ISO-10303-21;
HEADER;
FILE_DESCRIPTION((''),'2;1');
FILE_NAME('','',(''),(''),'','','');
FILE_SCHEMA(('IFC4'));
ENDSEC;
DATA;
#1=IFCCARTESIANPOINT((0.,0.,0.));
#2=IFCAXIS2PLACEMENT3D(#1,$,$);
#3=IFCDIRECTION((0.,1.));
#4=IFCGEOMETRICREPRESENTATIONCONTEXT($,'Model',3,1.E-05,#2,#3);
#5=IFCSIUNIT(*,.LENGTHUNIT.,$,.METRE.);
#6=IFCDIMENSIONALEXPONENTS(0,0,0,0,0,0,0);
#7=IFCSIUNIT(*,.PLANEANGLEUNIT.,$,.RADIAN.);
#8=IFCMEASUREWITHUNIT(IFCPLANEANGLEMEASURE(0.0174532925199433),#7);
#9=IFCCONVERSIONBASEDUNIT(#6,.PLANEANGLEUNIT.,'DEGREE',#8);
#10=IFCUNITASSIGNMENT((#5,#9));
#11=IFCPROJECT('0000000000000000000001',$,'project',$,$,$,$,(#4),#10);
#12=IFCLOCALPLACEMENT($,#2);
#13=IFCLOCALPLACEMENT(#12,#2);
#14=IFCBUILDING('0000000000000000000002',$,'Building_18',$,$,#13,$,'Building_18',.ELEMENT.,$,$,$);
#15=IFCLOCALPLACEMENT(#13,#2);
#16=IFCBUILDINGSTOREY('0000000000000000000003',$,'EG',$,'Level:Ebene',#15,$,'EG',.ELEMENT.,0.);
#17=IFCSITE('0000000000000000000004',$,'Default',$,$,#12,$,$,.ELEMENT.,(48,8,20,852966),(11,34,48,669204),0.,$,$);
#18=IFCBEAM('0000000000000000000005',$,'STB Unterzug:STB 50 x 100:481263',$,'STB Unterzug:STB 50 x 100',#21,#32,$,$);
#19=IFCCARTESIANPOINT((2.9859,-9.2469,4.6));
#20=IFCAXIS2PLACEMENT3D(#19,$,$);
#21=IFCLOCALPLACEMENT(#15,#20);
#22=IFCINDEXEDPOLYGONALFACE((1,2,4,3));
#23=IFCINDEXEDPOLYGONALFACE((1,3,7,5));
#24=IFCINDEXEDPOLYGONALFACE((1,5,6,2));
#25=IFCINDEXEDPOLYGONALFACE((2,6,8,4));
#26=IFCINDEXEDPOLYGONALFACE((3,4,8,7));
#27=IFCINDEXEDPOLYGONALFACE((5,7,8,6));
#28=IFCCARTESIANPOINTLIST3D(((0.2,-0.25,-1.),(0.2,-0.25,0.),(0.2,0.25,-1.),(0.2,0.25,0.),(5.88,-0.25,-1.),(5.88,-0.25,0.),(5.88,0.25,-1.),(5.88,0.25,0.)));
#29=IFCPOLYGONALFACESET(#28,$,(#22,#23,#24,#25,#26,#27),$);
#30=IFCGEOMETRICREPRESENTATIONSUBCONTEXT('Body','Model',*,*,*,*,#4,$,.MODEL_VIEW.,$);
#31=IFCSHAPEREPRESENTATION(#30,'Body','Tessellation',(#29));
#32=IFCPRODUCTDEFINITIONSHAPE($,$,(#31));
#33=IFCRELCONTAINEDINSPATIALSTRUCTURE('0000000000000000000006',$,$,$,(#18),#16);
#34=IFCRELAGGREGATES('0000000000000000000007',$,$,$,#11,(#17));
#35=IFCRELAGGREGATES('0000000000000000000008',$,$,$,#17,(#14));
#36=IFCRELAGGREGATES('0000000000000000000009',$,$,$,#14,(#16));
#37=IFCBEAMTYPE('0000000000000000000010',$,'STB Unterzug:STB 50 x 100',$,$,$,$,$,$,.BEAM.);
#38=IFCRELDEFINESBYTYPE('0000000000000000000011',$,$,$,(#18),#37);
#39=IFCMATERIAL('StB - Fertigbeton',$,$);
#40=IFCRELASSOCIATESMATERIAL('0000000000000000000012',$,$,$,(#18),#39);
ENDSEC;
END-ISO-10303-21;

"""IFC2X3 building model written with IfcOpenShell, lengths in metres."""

from ifc_helpers import new_model, entity, si_unit, converted_unit, direction, frame, origin, origin_2d_with_axis, place, context, subcontext, project, spatial, rectangle, extrude, material, type_object, element, save


model = new_model("IFC2X3")

# Units and contexts
model_context = context("Model", 3, precision=1e-05, world=origin(), true_north=direction((0.0, 1.0)))
body_context = subcontext(model_context, "Body", "Model", "MODEL_VIEW")
ifc_project = project(units=[si_unit("LENGTHUNIT", "METRE"), converted_unit("PLANEANGLEUNIT", "DEGREE", entity("IfcPlaneAngleMeasure", 0.0174532925199433), si_unit("PLANEANGLEUNIT", "RADIAN"), dimensions=[0, 0, 0, 0, 0, 0, 0])], contexts=[model_context])

# Site, building, storey
site_placement = place(None, origin())
site = spatial("IfcSite", under=ifc_project, at=site_placement, Name="Default", CompositionType="ELEMENT", RefLatitude=(48, 8, 20, 852966), RefLongitude=(11, 34, 48, 669204), RefElevation=0.0)
building_placement = place(site_placement, origin())
building = spatial("IfcBuilding", under=site, at=building_placement, Name="Building_18", LongName="Building_18", CompositionType="ELEMENT")
storey_placement = place(building_placement, origin())
storey = spatial("IfcBuildingStorey", under=building, at=storey_placement, Name="EG", ObjectType="Level:Ebene", LongName="EG", CompositionType="ELEMENT", Elevation=0.0)

# Beam
ifc_material_1 = material(Name="StB - Fertigbeton")
beam_type = type_object("IfcBeamType", Name="STB Unterzug:STB 50 x 100", PredefinedType="BEAM")
beam_placement = place(storey_placement, frame((2.9859, -9.2469, 4.6)))
element("IfcBeam", 1, at=beam_placement, inside=storey, type_object=beam_type, material=ifc_material_1, Name="STB Unterzug:STB 50 x 100:481263", ObjectType="STB Unterzug:STB 50 x 100", context=body_context, shape_type="SweptSolid", body=[
    extrude(rectangle(XDim=1.0, YDim=0.5, at=origin_2d_with_axis()), frame((0.2, 0.0, -0.5), z_axis=(1.0, 0.0, 0.0), x_axis=(0.0, 0.0, -1.0)), (0.0, 0.0, 1.0), 5.68),
])

save(model, "model.ifc")
